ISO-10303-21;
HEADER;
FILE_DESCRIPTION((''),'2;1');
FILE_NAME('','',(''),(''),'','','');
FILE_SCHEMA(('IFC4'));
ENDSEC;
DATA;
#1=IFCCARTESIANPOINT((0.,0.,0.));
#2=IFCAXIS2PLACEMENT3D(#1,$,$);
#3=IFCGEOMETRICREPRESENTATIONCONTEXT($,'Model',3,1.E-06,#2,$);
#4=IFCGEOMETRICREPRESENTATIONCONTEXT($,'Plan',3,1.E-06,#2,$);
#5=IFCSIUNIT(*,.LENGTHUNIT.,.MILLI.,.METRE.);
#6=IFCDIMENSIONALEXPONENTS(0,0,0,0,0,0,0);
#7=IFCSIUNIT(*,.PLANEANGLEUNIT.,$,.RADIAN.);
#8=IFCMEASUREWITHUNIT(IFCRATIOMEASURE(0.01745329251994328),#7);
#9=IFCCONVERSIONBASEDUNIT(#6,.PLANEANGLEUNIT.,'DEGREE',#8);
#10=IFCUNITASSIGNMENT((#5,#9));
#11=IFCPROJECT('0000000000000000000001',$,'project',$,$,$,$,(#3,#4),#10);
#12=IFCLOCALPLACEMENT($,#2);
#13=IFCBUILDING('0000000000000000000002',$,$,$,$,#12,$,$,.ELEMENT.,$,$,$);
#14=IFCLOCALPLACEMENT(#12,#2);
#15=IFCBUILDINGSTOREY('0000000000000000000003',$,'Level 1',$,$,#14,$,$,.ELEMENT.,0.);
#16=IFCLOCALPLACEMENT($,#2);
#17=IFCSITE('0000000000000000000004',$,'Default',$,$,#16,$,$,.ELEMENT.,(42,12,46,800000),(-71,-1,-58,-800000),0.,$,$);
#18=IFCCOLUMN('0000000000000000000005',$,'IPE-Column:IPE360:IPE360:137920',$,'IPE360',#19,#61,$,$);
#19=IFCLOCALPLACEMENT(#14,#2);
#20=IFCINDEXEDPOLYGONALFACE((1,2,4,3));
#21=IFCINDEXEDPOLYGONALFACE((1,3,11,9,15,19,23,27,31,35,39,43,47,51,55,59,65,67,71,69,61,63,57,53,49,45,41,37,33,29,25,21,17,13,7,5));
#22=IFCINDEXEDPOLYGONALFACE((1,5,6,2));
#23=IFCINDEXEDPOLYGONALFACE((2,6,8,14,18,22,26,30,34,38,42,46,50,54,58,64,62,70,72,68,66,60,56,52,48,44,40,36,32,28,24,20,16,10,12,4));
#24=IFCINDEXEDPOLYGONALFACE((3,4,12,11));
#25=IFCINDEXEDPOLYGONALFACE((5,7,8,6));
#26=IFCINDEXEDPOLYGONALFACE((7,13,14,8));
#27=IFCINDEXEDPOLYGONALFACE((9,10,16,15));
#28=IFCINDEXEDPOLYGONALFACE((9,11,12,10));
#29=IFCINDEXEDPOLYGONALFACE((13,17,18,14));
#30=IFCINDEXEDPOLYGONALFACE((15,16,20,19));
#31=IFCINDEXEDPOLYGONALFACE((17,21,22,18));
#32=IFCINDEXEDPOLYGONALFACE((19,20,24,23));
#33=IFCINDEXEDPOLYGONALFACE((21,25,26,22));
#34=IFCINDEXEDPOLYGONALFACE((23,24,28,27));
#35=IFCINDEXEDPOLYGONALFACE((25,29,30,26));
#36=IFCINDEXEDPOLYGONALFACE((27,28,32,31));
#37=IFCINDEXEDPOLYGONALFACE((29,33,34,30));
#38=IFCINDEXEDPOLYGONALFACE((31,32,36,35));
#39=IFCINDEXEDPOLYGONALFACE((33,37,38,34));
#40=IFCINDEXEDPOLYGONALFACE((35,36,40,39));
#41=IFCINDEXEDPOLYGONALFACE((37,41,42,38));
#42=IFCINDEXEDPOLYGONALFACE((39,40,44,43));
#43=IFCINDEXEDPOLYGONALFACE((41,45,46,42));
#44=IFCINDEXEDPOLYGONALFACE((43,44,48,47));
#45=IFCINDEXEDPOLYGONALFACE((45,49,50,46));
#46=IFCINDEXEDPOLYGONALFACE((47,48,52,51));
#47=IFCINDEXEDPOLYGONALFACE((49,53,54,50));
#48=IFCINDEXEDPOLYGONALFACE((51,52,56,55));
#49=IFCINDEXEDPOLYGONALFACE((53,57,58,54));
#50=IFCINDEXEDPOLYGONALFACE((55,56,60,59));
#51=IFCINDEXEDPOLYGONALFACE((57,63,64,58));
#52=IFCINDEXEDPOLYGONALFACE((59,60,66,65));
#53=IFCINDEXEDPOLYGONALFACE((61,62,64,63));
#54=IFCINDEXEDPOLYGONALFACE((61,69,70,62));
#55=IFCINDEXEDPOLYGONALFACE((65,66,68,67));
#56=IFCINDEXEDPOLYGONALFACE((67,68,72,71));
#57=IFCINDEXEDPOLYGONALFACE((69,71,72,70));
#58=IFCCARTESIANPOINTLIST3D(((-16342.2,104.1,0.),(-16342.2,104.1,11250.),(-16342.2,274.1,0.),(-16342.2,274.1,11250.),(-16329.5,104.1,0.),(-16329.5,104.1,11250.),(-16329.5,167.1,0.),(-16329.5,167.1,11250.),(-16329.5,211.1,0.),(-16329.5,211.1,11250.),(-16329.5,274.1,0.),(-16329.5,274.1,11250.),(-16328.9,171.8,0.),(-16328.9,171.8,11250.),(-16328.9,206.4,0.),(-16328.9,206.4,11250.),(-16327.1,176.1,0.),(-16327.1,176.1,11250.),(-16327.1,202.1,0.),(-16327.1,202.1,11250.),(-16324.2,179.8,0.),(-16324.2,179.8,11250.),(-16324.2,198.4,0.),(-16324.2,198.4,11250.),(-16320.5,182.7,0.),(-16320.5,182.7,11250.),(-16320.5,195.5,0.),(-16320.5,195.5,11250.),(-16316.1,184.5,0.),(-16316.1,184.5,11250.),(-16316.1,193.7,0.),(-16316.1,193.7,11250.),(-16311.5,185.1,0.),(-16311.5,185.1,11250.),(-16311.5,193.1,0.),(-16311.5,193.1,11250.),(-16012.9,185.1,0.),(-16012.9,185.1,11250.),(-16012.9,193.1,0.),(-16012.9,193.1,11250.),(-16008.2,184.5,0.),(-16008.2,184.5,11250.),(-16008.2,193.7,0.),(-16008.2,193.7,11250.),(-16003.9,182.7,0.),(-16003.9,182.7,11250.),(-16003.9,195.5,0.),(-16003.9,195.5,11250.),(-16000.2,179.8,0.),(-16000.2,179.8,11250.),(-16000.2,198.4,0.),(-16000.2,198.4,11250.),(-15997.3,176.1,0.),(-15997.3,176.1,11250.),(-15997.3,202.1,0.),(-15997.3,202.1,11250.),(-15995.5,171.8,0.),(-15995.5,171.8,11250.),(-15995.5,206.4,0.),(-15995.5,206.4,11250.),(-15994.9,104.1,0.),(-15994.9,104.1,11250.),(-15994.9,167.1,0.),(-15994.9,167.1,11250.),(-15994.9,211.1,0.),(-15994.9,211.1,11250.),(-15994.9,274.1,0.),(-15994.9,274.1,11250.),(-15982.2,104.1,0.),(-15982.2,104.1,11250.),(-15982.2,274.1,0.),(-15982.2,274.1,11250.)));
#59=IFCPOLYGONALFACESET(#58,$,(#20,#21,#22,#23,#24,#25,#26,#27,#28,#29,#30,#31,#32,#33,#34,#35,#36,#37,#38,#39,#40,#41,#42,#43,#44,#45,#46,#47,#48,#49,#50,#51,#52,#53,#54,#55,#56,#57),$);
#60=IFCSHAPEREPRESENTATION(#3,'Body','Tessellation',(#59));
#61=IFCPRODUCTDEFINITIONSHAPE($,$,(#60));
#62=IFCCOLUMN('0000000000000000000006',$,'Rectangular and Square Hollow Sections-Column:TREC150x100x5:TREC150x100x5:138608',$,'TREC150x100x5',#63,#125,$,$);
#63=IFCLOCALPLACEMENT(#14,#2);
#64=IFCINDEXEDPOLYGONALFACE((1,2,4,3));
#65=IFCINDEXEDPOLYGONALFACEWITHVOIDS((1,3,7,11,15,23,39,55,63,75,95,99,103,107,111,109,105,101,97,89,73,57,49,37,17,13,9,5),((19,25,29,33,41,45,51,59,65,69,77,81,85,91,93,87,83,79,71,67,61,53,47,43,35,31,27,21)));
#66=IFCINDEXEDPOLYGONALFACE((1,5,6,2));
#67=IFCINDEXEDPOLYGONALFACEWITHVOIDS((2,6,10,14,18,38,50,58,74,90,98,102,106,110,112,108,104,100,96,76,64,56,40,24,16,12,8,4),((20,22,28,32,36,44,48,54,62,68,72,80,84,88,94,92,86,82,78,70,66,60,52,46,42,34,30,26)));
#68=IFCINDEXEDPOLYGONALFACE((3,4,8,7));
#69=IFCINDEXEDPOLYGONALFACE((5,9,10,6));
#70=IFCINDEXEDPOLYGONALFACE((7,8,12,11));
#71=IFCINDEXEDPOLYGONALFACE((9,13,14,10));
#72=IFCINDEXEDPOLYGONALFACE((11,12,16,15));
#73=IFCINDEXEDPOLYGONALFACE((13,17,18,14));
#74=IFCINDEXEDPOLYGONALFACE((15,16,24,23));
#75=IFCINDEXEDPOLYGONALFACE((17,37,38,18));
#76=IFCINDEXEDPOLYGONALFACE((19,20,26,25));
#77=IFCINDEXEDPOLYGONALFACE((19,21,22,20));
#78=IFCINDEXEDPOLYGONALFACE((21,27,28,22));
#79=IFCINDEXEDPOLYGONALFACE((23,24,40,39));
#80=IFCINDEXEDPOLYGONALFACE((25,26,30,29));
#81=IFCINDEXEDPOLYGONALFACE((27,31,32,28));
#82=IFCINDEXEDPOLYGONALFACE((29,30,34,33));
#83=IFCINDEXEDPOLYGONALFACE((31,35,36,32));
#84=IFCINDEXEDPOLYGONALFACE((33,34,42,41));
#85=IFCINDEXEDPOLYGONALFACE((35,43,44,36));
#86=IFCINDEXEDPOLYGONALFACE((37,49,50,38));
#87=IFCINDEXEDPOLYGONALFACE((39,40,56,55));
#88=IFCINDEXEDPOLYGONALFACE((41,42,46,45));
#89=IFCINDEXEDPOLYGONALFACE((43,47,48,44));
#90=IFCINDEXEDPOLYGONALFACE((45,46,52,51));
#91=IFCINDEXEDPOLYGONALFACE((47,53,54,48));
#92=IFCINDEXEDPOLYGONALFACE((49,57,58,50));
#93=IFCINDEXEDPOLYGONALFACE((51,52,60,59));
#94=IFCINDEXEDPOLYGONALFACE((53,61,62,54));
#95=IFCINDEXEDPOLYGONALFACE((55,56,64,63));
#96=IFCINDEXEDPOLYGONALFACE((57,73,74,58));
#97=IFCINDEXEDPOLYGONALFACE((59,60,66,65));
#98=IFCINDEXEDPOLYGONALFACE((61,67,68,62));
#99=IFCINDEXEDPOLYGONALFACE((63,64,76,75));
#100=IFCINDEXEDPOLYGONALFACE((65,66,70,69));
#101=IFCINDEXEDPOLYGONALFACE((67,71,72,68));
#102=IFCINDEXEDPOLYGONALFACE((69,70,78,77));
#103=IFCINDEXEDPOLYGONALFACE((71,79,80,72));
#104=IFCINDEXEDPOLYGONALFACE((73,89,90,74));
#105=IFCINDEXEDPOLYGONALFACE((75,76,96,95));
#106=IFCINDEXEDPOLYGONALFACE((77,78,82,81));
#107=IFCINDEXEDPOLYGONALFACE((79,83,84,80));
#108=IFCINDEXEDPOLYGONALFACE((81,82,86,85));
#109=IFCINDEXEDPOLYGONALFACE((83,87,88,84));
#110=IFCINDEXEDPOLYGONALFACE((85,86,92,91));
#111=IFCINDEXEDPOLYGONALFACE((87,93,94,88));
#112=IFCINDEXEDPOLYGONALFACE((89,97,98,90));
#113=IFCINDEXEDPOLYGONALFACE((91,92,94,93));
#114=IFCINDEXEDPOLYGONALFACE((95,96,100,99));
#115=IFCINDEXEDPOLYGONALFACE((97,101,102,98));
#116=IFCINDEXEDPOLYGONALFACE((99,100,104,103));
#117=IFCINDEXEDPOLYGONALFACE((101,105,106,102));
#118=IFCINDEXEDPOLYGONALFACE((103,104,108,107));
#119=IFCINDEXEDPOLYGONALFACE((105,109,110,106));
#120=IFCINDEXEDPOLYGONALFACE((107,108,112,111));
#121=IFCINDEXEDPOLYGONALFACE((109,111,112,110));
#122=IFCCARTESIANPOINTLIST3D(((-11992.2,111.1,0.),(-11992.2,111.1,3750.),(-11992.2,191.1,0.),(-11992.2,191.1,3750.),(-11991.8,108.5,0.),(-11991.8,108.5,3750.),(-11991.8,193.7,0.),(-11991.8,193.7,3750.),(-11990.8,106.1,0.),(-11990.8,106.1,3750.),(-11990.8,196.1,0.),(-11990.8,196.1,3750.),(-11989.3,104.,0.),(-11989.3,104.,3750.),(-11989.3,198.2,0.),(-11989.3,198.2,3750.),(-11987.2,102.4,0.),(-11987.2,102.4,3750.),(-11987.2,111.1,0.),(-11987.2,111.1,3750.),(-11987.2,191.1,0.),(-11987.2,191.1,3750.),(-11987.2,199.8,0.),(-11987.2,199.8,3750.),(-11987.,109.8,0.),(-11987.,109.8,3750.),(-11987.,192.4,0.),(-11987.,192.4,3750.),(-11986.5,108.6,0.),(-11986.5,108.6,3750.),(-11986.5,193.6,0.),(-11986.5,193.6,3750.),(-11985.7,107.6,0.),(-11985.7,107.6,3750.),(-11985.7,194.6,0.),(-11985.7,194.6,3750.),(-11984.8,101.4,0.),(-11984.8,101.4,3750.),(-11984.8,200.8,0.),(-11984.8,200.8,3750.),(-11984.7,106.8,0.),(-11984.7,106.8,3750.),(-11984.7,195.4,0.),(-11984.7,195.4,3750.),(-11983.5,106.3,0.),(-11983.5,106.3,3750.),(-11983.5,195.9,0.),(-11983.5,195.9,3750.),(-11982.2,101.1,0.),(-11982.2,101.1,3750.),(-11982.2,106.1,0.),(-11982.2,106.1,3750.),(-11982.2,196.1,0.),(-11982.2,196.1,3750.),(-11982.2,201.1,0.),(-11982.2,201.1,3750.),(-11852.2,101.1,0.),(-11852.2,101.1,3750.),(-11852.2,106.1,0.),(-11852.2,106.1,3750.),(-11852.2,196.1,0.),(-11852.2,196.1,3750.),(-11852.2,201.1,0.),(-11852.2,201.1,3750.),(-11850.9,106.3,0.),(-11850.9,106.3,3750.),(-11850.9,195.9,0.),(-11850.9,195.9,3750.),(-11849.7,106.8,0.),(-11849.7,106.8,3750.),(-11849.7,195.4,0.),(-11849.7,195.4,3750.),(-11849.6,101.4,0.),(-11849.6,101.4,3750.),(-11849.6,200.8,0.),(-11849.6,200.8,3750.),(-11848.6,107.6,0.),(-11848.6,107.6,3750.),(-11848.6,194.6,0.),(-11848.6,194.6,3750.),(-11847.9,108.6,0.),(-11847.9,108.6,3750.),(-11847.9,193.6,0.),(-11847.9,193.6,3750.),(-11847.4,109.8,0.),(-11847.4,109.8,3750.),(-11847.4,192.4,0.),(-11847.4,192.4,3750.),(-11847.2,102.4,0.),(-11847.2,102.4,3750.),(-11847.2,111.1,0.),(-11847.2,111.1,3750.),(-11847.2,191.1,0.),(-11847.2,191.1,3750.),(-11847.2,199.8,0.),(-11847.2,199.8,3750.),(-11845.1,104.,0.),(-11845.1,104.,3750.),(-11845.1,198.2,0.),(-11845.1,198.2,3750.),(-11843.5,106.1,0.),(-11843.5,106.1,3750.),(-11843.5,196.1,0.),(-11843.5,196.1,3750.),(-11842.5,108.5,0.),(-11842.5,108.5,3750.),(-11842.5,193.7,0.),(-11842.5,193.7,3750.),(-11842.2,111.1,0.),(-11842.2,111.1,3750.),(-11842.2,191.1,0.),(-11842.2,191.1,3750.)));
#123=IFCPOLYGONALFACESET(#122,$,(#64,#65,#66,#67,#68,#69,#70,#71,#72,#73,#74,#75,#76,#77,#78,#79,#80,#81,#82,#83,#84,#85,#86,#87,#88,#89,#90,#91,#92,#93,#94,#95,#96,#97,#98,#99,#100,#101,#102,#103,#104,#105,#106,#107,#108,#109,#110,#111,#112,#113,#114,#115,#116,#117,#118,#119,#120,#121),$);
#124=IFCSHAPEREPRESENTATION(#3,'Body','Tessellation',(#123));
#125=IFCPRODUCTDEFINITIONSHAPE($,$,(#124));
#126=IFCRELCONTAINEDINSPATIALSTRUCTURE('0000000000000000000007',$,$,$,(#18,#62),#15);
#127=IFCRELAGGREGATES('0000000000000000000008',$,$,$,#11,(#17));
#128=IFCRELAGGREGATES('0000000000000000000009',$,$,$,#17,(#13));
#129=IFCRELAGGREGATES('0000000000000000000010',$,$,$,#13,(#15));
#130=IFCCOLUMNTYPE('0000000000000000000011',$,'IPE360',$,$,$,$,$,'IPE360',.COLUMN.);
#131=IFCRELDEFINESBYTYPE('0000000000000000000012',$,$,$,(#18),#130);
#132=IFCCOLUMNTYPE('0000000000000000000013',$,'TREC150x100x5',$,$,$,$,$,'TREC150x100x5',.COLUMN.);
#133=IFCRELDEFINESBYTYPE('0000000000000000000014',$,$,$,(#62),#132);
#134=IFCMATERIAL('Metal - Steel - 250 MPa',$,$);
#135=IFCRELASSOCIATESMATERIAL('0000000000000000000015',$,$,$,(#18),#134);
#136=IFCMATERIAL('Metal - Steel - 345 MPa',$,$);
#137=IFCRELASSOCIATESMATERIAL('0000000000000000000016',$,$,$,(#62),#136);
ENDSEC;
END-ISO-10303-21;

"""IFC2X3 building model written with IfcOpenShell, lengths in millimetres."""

from ifc_helpers import new_model, entity, si_unit, converted_unit, frame, frame_2d, origin, place, context, project, spatial, polyline, circle_curve, parameter, trimmed, segment, composite_curve, outline, extrude, source, transform, mapped, material, type_object, type_shapes, element, save


model = new_model("IFC2X3")

# Units and contexts
model_context = context("Model", 3, precision=1e-06, world=origin())
plan_context = context("Plan", 3, precision=1e-06, world=origin())
ifc_project = project(units=[si_unit("LENGTHUNIT", "METRE", prefix="MILLI"), converted_unit("PLANEANGLEUNIT", "DEGREE", entity("IfcRatioMeasure", 0.01745329251994328), si_unit("PLANEANGLEUNIT", "RADIAN"), dimensions=[0, 0, 0, 0, 0, 0, 0])], contexts=[model_context, plan_context])

# Site, building, storey
site_placement = place(None, origin())
site = spatial("IfcSite", under=ifc_project, at=site_placement, Name="Default", CompositionType="ELEMENT", RefLatitude=(42, 12, 46, 800000), RefLongitude=(-71, -1, -58, -800000), RefElevation=0.0)
building_placement = place(None, origin())
building = spatial("IfcBuilding", under=site, at=building_placement, CompositionType="ELEMENT")
storey_placement = place(building_placement, origin())
storey = spatial("IfcBuildingStorey", under=building, at=storey_placement, Name="Level 1", CompositionType="ELEMENT", Elevation=0.0)

# Columns
ifc_material_1 = material(Name="Metal - Steel - 250 MPa")
column_type_1 = type_object("IfcColumnType", Name="IPE360", ElementType="IPE360", PredefinedType="COLUMN")
shared_shape_1 = source(origin(), model_context, "Body", "SweptSolid", [
    extrude(outline(composite_curve([segment(polyline([(-85.0, -180.0), (85.0, -180.0)]), True, "CONTINUOUS"), segment(polyline([(85.0, -180.0), (85.0, -167.3)]), True, "CONTINUOUS"), segment(polyline([(85.0, -167.3), (22.0, -167.3)]), True, "CONTINUOUS"), segment(trimmed(circle_curve(frame_2d((22.0, -149.3), x_axis=(-1.0, 0.0)), 18.0), [parameter(0.0)], [parameter(90.0)], True, "PARAMETER"), False, "CONTINUOUS"), segment(polyline([(4.0, -149.3), (4.0, 149.3)]), True, "CONTINUOUS"), segment(trimmed(circle_curve(frame_2d((22.0, 149.3), x_axis=(-1.0, 0.0)), 18.0), [parameter(270.0)], [parameter(0.0)], True, "PARAMETER"), False, "CONTINUOUS"), segment(polyline([(22.0, 167.3), (85.0, 167.3)]), True, "CONTINUOUS"), segment(polyline([(85.0, 167.3), (85.0, 180.0)]), True, "CONTINUOUS"), segment(polyline([(85.0, 180.0), (-85.0, 180.0)]), True, "CONTINUOUS"), segment(polyline([(-85.0, 180.0), (-85.0, 167.3)]), True, "CONTINUOUS"), segment(polyline([(-85.0, 167.3), (-22.0, 167.3)]), True, "CONTINUOUS"), segment(trimmed(circle_curve(frame_2d((-22.0, 149.3), x_axis=(-1.0, 0.0)), 18.0), [parameter(180.0)], [parameter(270.0)], True, "PARAMETER"), False, "CONTINUOUS"), segment(polyline([(-4.0, 149.3), (-4.0, -149.3)]), True, "CONTINUOUS"), segment(trimmed(circle_curve(frame_2d((-22.0, -149.3), x_axis=(-1.0, 0.0)), 18.0), [parameter(90.0)], [parameter(180.0)], True, "PARAMETER"), False, "CONTINUOUS"), segment(polyline([(-22.0, -167.3), (-85.0, -167.3)]), True, "CONTINUOUS"), segment(polyline([(-85.0, -167.3), (-85.0, -180.0)]), True, "CONTINUOUS")], self_intersect=False)), frame((0.0, 0.0, 0.0), z_axis=(0.0, 0.0, 1.0), x_axis=(-1.0, 0.0, 0.0)), (0.0, 0.0, 1.0), 11250.0),
])
type_shapes(column_type_1, [shared_shape_1])
for number, where, z_axis, x_axis, name in (
    (1, (-16162.2, 189.1, 0.0), (0.0, 0.0, 1.0), (0.0, 1.0, 0.0), "IPE-Column:IPE360:IPE360:137920"),
):
    element("IfcColumn", number, at=place(storey_placement, frame(where, z_axis=z_axis, x_axis=x_axis)), inside=storey, type_object=column_type_1, material=ifc_material_1, Name=name, ObjectType="IPE360", context=model_context, shape_type="MappedRepresentation", body=[
        mapped(shared_shape_1, transform((0.0, 0.0, 0.0), scale=1.0)),
    ])
ifc_material_2 = material(Name="Metal - Steel - 345 MPa")
column_type_2 = type_object("IfcColumnType", Name="TREC150x100x5", ElementType="TREC150x100x5", PredefinedType="COLUMN")
shared_shape_2 = source(origin(), model_context, "Body", "SweptSolid", [
    extrude(outline(composite_curve([segment(polyline([(-40.0, -75.0), (40.0, -75.0)]), True, "CONTINUOUS"), segment(trimmed(circle_curve(frame_2d((40.0, -65.0), x_axis=(-1.0, 0.0)), 10.0), [parameter(90.0)], [parameter(180.0)], True, "PARAMETER"), True, "CONTINUOUS"), segment(polyline([(50.0, -65.0), (50.0, 65.0)]), True, "CONTINUOUS"), segment(trimmed(circle_curve(frame_2d((40.0, 65.0), x_axis=(-1.0, 0.0)), 10.0), [parameter(180.0)], [parameter(270.0)], True, "PARAMETER"), True, "CONTINUOUS"), segment(polyline([(40.0, 75.0), (-40.0, 75.0)]), True, "CONTINUOUS"), segment(trimmed(circle_curve(frame_2d((-40.0, 65.0), x_axis=(-1.0, 0.0)), 10.0), [parameter(270.0)], [parameter(360.0)], True, "PARAMETER"), True, "CONTINUOUS"), segment(polyline([(-50.0, 65.0), (-50.0, -65.0)]), True, "CONTINUOUS"), segment(trimmed(circle_curve(frame_2d((-40.0, -65.0), x_axis=(-1.0, 0.0)), 10.0), [parameter(360.0)], [parameter(90.0)], True, "PARAMETER"), True, "CONTINUOUS")], self_intersect=False), holes=[composite_curve([segment(trimmed(circle_curve(frame_2d((-40.0, -65.0), x_axis=(-1.0, 0.0)), 5.0), [parameter(0.0)], [parameter(90.0)], True, "PARAMETER"), False, "CONTINUOUS"), segment(polyline([(-45.0, -65.0), (-45.0, 65.0)]), True, "CONTINUOUS"), segment(trimmed(circle_curve(frame_2d((-40.0, 65.0), x_axis=(-1.0, 0.0)), 5.0), [parameter(270.0)], [parameter(360.0)], True, "PARAMETER"), False, "CONTINUOUS"), segment(polyline([(-40.0, 70.0), (40.0, 70.0)]), True, "CONTINUOUS"), segment(trimmed(circle_curve(frame_2d((40.0, 65.0), x_axis=(-1.0, 0.0)), 5.0), [parameter(180.0)], [parameter(270.0)], True, "PARAMETER"), False, "CONTINUOUS"), segment(polyline([(45.0, 65.0), (45.0, -65.0)]), True, "CONTINUOUS"), segment(trimmed(circle_curve(frame_2d((40.0, -65.0), x_axis=(-1.0, 0.0)), 5.0), [parameter(90.0)], [parameter(180.0)], True, "PARAMETER"), False, "CONTINUOUS"), segment(polyline([(40.0, -70.0), (-40.0, -70.0)]), True, "CONTINUOUS")], self_intersect=False)]), frame((0.0, 0.0, 0.0), z_axis=(0.0, 0.0, 1.0), x_axis=(-1.0, 0.0, 0.0)), (0.0, 0.0, 1.0), 3750.0),
])
type_shapes(column_type_2, [shared_shape_2])
for number, where, z_axis, x_axis, name in (
    (2, (-11917.2, 151.1, 0.0), (0.0, 0.0, 1.0), (0.0, 1.0, 0.0), "Rectangular and Square Hollow Sections-Column:TREC150x100x5:TREC150x100x5:138608"),
):
    element("IfcColumn", number, at=place(storey_placement, frame(where, z_axis=z_axis, x_axis=x_axis)), inside=storey, type_object=column_type_2, material=ifc_material_2, Name=name, ObjectType="TREC150x100x5", context=model_context, shape_type="MappedRepresentation", body=[
        mapped(shared_shape_2, transform((0.0, 0.0, 0.0), scale=1.0)),
    ])

save(model, "model.ifc")
